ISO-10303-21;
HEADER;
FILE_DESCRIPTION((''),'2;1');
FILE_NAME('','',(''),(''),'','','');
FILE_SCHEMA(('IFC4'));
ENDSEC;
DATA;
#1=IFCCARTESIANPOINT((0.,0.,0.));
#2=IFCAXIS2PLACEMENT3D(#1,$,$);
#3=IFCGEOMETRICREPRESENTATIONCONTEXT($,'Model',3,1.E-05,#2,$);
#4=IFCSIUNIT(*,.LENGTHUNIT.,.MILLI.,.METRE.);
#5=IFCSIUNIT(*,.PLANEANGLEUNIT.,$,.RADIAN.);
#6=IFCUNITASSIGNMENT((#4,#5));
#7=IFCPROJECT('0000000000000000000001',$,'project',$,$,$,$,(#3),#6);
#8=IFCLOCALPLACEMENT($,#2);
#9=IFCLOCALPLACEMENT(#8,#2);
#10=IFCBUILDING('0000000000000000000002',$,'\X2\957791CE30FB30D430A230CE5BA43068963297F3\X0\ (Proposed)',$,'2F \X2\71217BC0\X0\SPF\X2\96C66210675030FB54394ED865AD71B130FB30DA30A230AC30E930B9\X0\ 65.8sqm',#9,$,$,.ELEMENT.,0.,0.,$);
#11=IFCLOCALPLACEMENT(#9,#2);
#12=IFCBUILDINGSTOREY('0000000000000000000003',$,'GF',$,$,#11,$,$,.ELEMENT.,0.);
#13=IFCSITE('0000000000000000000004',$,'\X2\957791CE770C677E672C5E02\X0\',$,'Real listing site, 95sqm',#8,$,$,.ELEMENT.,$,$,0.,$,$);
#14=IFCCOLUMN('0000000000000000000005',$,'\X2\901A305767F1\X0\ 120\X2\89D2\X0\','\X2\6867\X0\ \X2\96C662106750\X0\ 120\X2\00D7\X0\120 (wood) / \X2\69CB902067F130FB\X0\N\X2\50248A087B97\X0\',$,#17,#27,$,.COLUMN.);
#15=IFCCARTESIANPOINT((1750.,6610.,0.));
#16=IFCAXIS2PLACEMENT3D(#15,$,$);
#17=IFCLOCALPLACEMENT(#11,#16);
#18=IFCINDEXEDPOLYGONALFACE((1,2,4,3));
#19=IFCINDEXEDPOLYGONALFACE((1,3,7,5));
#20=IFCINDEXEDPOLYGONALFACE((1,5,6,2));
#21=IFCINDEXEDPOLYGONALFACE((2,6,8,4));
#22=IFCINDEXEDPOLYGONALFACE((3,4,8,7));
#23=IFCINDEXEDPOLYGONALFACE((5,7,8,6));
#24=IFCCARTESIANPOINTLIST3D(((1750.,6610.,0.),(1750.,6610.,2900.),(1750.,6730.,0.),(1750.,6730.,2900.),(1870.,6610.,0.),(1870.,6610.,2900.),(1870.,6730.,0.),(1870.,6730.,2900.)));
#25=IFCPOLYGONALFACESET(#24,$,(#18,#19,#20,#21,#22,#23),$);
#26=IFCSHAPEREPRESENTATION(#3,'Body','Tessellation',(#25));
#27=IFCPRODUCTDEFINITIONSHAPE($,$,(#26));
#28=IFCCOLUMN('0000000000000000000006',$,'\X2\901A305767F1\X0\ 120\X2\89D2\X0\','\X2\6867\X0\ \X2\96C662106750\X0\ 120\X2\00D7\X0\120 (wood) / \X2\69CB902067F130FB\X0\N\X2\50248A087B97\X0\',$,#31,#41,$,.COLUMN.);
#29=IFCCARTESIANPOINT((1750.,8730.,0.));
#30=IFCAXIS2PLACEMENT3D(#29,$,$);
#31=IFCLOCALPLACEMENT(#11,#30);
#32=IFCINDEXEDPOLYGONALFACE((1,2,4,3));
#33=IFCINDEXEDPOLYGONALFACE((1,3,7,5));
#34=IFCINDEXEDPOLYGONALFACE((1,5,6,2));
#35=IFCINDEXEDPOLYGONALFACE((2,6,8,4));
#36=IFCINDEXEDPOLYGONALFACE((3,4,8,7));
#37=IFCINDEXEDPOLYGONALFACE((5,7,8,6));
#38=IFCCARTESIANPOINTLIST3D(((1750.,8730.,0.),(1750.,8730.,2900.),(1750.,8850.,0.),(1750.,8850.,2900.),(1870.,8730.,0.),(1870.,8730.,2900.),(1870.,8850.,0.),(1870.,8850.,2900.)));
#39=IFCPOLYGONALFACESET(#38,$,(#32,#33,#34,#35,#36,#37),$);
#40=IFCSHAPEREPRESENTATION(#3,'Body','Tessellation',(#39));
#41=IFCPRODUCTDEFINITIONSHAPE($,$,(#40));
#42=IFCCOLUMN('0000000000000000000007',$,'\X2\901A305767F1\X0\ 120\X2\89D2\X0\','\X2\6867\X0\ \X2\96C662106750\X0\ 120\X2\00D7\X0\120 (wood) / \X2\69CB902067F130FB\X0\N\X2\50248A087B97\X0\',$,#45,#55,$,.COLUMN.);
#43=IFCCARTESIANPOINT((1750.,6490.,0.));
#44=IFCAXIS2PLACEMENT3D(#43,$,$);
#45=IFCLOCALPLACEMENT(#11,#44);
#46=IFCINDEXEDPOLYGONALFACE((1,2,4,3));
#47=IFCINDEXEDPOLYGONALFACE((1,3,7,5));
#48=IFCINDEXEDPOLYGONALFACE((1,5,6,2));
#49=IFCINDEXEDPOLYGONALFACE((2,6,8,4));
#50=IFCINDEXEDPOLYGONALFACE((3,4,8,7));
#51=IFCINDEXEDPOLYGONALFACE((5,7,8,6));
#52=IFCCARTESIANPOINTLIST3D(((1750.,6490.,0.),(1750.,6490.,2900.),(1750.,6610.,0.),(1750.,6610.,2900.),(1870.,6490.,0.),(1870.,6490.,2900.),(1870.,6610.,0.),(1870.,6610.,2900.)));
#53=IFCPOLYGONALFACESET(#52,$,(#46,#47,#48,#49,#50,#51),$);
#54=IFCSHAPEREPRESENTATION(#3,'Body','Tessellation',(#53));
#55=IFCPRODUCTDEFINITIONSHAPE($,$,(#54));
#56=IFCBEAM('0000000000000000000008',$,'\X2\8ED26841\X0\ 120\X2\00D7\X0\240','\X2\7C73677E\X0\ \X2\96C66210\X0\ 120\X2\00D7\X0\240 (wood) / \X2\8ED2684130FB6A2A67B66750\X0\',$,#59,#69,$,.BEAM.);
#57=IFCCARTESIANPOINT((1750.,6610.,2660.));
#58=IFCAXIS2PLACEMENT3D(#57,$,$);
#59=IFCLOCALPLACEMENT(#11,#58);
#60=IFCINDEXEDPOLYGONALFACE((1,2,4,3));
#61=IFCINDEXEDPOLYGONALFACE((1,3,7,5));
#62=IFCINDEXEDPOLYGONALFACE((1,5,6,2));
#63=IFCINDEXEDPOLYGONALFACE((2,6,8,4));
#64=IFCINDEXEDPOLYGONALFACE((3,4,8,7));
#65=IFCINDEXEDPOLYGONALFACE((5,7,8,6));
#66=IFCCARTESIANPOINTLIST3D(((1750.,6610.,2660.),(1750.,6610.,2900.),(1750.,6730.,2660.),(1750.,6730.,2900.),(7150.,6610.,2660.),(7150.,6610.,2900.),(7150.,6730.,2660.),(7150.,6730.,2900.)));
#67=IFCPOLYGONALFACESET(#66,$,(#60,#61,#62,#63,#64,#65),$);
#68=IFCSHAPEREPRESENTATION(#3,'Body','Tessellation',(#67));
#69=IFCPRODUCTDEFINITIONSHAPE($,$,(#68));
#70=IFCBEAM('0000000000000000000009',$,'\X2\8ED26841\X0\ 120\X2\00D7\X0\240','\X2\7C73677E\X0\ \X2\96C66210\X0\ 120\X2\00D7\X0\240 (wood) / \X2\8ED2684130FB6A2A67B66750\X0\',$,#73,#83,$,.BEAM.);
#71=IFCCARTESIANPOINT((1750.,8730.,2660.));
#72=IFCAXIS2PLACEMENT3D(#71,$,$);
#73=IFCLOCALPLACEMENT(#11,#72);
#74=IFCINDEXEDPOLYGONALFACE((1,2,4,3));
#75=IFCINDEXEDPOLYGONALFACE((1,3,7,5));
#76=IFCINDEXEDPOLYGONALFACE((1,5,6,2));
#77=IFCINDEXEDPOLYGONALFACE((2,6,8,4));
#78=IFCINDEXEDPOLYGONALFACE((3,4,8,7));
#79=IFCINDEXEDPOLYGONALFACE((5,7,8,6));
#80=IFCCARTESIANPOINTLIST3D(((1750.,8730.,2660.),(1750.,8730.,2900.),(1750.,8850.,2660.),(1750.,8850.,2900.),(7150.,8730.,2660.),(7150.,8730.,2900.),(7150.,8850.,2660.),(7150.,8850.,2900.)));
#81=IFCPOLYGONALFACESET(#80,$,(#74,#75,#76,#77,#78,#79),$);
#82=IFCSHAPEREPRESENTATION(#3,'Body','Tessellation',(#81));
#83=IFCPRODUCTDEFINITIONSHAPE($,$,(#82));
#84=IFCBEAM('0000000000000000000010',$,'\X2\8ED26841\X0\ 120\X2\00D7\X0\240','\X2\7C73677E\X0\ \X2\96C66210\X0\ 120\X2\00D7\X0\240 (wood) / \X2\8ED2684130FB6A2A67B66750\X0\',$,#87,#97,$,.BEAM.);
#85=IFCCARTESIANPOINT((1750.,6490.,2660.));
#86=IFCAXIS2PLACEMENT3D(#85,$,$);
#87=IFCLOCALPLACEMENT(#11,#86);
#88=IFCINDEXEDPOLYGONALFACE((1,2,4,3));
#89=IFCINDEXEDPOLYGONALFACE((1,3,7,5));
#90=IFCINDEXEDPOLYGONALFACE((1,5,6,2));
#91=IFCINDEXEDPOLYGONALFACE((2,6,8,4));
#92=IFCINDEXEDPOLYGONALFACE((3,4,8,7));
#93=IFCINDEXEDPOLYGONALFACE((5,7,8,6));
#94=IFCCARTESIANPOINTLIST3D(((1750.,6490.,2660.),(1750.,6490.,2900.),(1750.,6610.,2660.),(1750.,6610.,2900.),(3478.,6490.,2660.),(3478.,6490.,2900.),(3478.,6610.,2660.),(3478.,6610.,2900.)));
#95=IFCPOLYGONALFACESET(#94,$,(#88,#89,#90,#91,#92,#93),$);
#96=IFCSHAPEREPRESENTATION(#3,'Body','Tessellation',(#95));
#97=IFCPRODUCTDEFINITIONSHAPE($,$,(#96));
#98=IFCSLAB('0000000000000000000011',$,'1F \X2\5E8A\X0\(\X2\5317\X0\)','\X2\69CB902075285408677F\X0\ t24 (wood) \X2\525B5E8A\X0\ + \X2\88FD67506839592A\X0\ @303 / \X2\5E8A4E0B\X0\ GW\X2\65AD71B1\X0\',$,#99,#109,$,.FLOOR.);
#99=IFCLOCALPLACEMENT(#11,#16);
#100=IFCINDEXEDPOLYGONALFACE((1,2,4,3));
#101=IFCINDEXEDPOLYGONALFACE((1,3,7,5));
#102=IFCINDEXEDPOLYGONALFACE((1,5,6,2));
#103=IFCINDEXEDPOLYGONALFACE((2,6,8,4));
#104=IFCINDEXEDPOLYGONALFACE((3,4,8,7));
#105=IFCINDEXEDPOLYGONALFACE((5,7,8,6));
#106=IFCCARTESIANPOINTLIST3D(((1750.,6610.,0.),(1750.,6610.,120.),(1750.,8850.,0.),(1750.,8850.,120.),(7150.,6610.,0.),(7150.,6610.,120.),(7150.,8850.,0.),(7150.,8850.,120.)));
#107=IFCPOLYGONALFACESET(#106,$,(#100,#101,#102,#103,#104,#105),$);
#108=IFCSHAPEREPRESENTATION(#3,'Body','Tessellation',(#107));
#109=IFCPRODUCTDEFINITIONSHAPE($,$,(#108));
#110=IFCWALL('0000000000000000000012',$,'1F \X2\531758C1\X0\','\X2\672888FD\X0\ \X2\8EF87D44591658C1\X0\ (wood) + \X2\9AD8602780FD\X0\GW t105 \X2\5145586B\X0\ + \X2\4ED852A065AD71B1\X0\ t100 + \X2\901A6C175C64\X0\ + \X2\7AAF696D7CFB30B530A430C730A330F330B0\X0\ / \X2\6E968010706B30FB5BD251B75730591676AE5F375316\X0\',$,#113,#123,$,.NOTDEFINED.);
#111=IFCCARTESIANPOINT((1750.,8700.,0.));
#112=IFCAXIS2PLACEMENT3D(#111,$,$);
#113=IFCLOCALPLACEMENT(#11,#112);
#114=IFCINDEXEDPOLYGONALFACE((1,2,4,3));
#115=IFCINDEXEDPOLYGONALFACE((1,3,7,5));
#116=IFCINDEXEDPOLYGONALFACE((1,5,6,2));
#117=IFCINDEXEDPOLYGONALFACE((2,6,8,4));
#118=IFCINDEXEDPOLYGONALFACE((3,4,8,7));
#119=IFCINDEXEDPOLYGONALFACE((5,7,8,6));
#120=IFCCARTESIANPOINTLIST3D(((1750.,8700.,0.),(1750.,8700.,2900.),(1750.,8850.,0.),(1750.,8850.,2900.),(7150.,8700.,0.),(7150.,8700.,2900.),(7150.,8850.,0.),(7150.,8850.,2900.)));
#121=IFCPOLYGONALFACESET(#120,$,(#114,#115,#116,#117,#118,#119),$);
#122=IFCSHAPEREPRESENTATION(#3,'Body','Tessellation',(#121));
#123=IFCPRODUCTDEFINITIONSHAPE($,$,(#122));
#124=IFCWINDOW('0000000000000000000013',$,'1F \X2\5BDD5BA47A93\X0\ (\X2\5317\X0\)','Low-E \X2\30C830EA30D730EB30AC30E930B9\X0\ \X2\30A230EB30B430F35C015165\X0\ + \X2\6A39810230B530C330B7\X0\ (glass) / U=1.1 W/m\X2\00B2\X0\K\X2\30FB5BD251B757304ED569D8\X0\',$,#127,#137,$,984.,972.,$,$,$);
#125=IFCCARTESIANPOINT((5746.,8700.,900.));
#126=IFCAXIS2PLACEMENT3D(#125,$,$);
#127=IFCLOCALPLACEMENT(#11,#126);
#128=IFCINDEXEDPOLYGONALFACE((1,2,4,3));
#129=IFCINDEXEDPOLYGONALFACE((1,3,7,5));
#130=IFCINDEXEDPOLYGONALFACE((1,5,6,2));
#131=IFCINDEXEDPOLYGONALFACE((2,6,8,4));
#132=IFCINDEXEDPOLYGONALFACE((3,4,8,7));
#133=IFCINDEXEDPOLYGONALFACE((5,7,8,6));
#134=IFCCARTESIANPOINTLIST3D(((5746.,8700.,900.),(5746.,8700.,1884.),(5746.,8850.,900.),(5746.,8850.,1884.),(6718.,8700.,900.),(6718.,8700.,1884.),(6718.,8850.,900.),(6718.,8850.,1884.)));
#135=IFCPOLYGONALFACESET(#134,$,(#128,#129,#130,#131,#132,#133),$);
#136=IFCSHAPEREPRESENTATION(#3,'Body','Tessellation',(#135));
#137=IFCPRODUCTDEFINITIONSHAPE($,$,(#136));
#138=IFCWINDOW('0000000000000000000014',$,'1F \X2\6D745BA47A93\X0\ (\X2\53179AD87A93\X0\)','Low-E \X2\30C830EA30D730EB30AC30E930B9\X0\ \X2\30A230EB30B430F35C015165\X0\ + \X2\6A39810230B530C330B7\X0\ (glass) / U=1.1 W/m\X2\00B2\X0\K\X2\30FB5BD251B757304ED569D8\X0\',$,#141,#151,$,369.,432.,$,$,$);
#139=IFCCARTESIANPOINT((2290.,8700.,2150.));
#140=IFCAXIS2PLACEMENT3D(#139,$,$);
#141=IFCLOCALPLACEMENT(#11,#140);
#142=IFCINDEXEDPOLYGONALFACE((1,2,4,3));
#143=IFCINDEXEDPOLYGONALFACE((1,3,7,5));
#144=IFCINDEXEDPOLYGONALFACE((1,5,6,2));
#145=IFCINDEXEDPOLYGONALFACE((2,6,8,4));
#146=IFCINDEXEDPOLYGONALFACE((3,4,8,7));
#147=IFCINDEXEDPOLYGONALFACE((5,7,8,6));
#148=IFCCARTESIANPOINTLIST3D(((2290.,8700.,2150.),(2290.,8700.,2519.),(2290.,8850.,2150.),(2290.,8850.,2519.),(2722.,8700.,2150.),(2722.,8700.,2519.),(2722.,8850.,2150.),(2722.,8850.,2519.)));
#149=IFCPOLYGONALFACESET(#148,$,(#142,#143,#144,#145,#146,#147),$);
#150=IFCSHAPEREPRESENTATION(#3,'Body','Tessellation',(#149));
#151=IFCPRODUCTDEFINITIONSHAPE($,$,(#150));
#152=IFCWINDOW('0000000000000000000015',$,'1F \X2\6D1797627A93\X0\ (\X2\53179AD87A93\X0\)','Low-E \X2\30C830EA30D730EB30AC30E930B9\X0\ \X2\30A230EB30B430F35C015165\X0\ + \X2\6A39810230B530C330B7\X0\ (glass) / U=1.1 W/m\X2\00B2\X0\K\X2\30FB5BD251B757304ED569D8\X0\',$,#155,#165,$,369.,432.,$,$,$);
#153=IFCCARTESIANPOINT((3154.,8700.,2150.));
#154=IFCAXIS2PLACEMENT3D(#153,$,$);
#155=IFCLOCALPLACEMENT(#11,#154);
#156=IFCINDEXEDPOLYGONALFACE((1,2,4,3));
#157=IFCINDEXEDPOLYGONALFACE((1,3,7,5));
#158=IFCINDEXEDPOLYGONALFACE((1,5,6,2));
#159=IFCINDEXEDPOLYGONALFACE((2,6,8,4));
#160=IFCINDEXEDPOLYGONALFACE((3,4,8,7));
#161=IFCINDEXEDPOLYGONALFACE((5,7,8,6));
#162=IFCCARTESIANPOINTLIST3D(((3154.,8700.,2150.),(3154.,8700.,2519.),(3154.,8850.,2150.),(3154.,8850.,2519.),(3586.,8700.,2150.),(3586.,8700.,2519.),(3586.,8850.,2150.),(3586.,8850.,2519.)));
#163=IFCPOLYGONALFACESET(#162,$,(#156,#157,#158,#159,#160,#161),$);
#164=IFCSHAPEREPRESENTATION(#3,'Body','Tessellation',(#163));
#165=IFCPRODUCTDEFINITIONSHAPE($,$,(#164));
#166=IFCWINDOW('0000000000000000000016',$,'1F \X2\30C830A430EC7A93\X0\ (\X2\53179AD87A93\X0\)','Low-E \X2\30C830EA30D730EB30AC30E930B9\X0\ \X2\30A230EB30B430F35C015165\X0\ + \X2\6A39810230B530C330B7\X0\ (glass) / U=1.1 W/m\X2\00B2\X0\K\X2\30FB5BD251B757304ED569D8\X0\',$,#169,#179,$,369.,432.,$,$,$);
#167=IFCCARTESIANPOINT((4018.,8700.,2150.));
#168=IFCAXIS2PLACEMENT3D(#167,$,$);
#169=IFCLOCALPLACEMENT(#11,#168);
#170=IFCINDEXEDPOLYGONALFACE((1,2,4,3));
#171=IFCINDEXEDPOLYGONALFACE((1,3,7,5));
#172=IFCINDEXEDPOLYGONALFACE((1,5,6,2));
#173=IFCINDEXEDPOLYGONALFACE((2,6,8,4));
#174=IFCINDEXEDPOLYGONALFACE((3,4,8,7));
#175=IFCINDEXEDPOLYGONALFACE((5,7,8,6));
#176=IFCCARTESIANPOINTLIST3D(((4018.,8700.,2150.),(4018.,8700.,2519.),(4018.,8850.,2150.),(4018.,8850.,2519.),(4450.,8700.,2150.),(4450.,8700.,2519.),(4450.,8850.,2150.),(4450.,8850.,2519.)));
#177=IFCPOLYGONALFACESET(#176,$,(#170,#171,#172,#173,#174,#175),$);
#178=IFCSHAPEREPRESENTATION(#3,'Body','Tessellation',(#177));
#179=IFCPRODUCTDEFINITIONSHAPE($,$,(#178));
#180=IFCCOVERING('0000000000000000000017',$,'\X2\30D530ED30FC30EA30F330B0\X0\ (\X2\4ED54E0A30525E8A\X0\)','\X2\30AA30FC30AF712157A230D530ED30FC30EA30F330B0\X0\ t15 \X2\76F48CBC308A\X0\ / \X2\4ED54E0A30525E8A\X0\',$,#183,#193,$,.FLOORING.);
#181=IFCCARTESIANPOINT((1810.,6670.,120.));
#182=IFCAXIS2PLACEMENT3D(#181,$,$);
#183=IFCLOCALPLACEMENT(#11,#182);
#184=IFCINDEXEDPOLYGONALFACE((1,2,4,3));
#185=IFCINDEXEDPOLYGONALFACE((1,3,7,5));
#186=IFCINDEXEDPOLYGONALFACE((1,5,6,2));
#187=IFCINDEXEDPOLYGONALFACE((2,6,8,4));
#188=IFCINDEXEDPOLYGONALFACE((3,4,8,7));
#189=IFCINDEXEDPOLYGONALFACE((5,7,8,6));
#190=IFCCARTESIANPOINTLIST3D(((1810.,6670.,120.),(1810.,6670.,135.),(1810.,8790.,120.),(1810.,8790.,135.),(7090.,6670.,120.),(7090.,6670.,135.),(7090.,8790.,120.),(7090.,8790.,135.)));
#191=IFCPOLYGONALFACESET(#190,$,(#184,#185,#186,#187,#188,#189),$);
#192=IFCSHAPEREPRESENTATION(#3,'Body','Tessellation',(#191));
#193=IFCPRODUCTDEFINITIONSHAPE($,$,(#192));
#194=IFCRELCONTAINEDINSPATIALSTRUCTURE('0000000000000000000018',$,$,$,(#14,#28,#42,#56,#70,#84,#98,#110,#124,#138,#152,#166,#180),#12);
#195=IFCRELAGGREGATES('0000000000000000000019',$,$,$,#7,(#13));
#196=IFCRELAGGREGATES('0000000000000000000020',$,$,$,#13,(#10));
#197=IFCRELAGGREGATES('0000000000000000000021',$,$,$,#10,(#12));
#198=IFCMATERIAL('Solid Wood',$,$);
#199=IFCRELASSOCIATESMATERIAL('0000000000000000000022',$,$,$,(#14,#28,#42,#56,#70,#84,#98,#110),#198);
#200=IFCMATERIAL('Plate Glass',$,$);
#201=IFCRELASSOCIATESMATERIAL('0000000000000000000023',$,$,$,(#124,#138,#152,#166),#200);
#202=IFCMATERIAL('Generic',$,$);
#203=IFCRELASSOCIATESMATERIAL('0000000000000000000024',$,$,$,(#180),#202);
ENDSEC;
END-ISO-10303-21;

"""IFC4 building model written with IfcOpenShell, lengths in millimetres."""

from ifc_helpers import new_model, si_unit, frame, frame_2d, origin, place, context, project, spatial, rectangle, extrude, material, element, fill, save


model = new_model("IFC4")

# Units and contexts
model_context = context("Model", 3, precision=1e-05, world=origin())
ifc_project = project(units=[si_unit("LENGTHUNIT", "METRE", prefix="MILLI"), si_unit("PLANEANGLEUNIT", "RADIAN")], contexts=[model_context])

# Site, building, storey
site_placement = place(None, origin())
site = spatial("IfcSite", under=ifc_project, at=site_placement, Name="長野県松本市", ObjectType="Real listing site, 95sqm", CompositionType="ELEMENT", RefElevation=0.0)
building_placement = place(site_placement, origin())
building = spatial("IfcBuilding", under=site, at=building_placement, Name="長野・ピアノ室と防音 (Proposed)", ObjectType="2F 無節SPF集成材・吹付断熱・ペアガラス 65.8sqm", CompositionType="ELEMENT", ElevationOfRefHeight=0.0, ElevationOfTerrain=0.0)
storey_placement = place(building_placement, origin())
storey = spatial("IfcBuildingStorey", under=building, at=storey_placement, Name="GF", CompositionType="ELEMENT", Elevation=0.0)

# Columns
ifc_material_1 = material(Name="Solid Wood")
column_1_placement = place(storey_placement, frame((1750.0, 6610.0, 0.0)))
element("IfcColumn", 1, at=column_1_placement, inside=storey, material=ifc_material_1, Name="通し柱 120角", Description="桧 集成材 120×120 (wood) / 構造柱・N値計算", PredefinedType="COLUMN", context=model_context, shape_type="SweptSolid", body=[
    extrude(rectangle(XDim=120.0, YDim=120.0, at=frame_2d((60.0, 60.0))), frame((1750.0, 6610.0, 0.0)), (0.0, 0.0, 1.0), 2900.0),
])
column_2_placement = place(storey_placement, frame((1750.0, 8730.0, 0.0)))
element("IfcColumn", 2, at=column_2_placement, inside=storey, material=ifc_material_1, Name="通し柱 120角", Description="桧 集成材 120×120 (wood) / 構造柱・N値計算", PredefinedType="COLUMN", context=model_context, shape_type="SweptSolid", body=[
    extrude(rectangle(XDim=120.0, YDim=120.0, at=frame_2d((60.0, 60.0))), frame((1750.0, 8730.0, 0.0)), (0.0, 0.0, 1.0), 2900.0),
])
column_3_placement = place(storey_placement, frame((1750.0, 6490.0, 0.0)))
element("IfcColumn", 3, at=column_3_placement, inside=storey, material=ifc_material_1, Name="通し柱 120角", Description="桧 集成材 120×120 (wood) / 構造柱・N値計算", PredefinedType="COLUMN", context=model_context, shape_type="SweptSolid", body=[
    extrude(rectangle(XDim=120.0, YDim=120.0, at=frame_2d((60.0, 60.0))), frame((1750.0, 6490.0, 0.0)), (0.0, 0.0, 1.0), 2900.0),
])

# Beams
beam_1_placement = place(storey_placement, frame((1750.0, 6610.0, 2660.0)))
element("IfcBeam", 4, at=beam_1_placement, inside=storey, material=ifc_material_1, Name="軒桁 120×240", Description="米松 集成 120×240 (wood) / 軒桁・横架材", PredefinedType="BEAM", context=model_context, shape_type="SweptSolid", body=[
    extrude(rectangle(XDim=5400.0, YDim=120.0, at=frame_2d((2700.0, 60.0))), frame((1750.0, 6610.0, 2660.0)), (0.0, 0.0, 1.0), 240.0),
])
beam_2_placement = place(storey_placement, frame((1750.0, 8730.0, 2660.0)))
element("IfcBeam", 5, at=beam_2_placement, inside=storey, material=ifc_material_1, Name="軒桁 120×240", Description="米松 集成 120×240 (wood) / 軒桁・横架材", PredefinedType="BEAM", context=model_context, shape_type="SweptSolid", body=[
    extrude(rectangle(XDim=5400.0, YDim=120.0, at=frame_2d((2700.0, 60.0))), frame((1750.0, 8730.0, 2660.0)), (0.0, 0.0, 1.0), 240.0),
])
beam_3_placement = place(storey_placement, frame((1750.0, 6490.0, 2660.0)))
element("IfcBeam", 6, at=beam_3_placement, inside=storey, material=ifc_material_1, Name="軒桁 120×240", Description="米松 集成 120×240 (wood) / 軒桁・横架材", PredefinedType="BEAM", context=model_context, shape_type="SweptSolid", body=[
    extrude(rectangle(XDim=1728.0, YDim=120.0, at=frame_2d((864.0, 60.0))), frame((1750.0, 6490.0, 2660.0)), (0.0, 0.0, 1.0), 240.0),
])

# Slab
slab_placement = place(storey_placement, frame((1750.0, 6610.0, 0.0)))
element("IfcSlab", 7, at=slab_placement, inside=storey, material=ifc_material_1, Name="1F 床(北)", Description="構造用合板 t24 (wood) 剛床 + 製材根太 @303 / 床下 GW断熱", PredefinedType="FLOOR", context=model_context, shape_type="SweptSolid", body=[
    extrude(rectangle(XDim=5400.0, YDim=2240.0, at=frame_2d((2700.0, 1120.0))), frame((1750.0, 6610.0, 0.0)), (0.0, 0.0, 1.0), 120.0),
])

# Wall, openings, windows
wall_1_placement = place(storey_placement, frame((1750.0, 8700.0, 0.0)))
wall_1 = element("IfcWall", 8, at=wall_1_placement, inside=storey, material=ifc_material_1, Name="1F 北壁", Description="木製 軸組外壁 (wood) + 高性能GW t105 充填 + 付加断熱 t100 + 通気層 + 窯業系サイディング / 準耐火・寒冷地外皮強化", PredefinedType="NOTDEFINED", context=model_context, shape_type="SweptSolid", body=[
    extrude(rectangle(XDim=5400.0, YDim=150.0, at=frame_2d((2700.0, 75.0))), frame((1750.0, 8700.0, 0.0)), (0.0, 0.0, 1.0), 2900.0),
])
opening_1_placement = place(storey_placement, frame((5746.0, 8700.0, 900.0)))
opening_1 = element("IfcOpeningElement", 9, at=opening_1_placement, cuts=wall_1, PredefinedType="NOTDEFINED", context=model_context, shape_type="SweptSolid", body=[
    extrude(rectangle(XDim=972.0, YDim=150.0, at=frame_2d((486.0, 75.0))), frame((5746.0, 8700.0, 900.0)), (0.0, 0.0, 1.0), 984.0),
])
opening_2_placement = place(storey_placement, frame((2290.0, 8700.0, 2150.0)))
opening_2 = element("IfcOpeningElement", 10, at=opening_2_placement, cuts=wall_1, PredefinedType="NOTDEFINED", context=model_context, shape_type="SweptSolid", body=[
    extrude(rectangle(XDim=432.0, YDim=150.0, at=frame_2d((216.0, 75.0))), frame((2290.0, 8700.0, 2150.0)), (0.0, 0.0, 1.0), 369.0),
])
opening_3_placement = place(storey_placement, frame((3154.0, 8700.0, 2150.0)))
opening_3 = element("IfcOpeningElement", 11, at=opening_3_placement, cuts=wall_1, PredefinedType="NOTDEFINED", context=model_context, shape_type="SweptSolid", body=[
    extrude(rectangle(XDim=432.0, YDim=150.0, at=frame_2d((216.0, 75.0))), frame((3154.0, 8700.0, 2150.0)), (0.0, 0.0, 1.0), 369.0),
])
opening_4_placement = place(storey_placement, frame((4018.0, 8700.0, 2150.0)))
opening_4 = element("IfcOpeningElement", 12, at=opening_4_placement, cuts=wall_1, PredefinedType="NOTDEFINED", context=model_context, shape_type="SweptSolid", body=[
    extrude(rectangle(XDim=432.0, YDim=150.0, at=frame_2d((216.0, 75.0))), frame((4018.0, 8700.0, 2150.0)), (0.0, 0.0, 1.0), 369.0),
])
ifc_material_2 = material(Name="Plate Glass")
window_1_placement = place(storey_placement, frame((5746.0, 8700.0, 900.0)))
window_1 = element("IfcWindow", 13, at=window_1_placement, inside=storey, material=ifc_material_2, Name="1F 寝室窓 (北)", Description="Low-E トリプルガラス アルゴン封入 + 樹脂サッシ (glass) / U=1.1 W/m²K・寒冷地仕様", OverallHeight=984.0, OverallWidth=972.0, context=model_context, shape_type="SweptSolid", body=[
    extrude(rectangle(XDim=972.0, YDim=150.0, at=frame_2d((486.0, 75.0))), frame((5746.0, 8700.0, 900.0)), (0.0, 0.0, 1.0), 984.0),
])
fill(opening_1, window_1)
window_2_placement = place(storey_placement, frame((2290.0, 8700.0, 2150.0)))
window_2 = element("IfcWindow", 14, at=window_2_placement, inside=storey, material=ifc_material_2, Name="1F 浴室窓 (北高窓)", Description="Low-E トリプルガラス アルゴン封入 + 樹脂サッシ (glass) / U=1.1 W/m²K・寒冷地仕様", OverallHeight=369.0, OverallWidth=432.0, context=model_context, shape_type="SweptSolid", body=[
    extrude(rectangle(XDim=432.0, YDim=150.0, at=frame_2d((216.0, 75.0))), frame((2290.0, 8700.0, 2150.0)), (0.0, 0.0, 1.0), 369.0),
])
fill(opening_2, window_2)
window_3_placement = place(storey_placement, frame((3154.0, 8700.0, 2150.0)))
window_3 = element("IfcWindow", 15, at=window_3_placement, inside=storey, material=ifc_material_2, Name="1F 洗面窓 (北高窓)", Description="Low-E トリプルガラス アルゴン封入 + 樹脂サッシ (glass) / U=1.1 W/m²K・寒冷地仕様", OverallHeight=369.0, OverallWidth=432.0, context=model_context, shape_type="SweptSolid", body=[
    extrude(rectangle(XDim=432.0, YDim=150.0, at=frame_2d((216.0, 75.0))), frame((3154.0, 8700.0, 2150.0)), (0.0, 0.0, 1.0), 369.0),
])
fill(opening_3, window_3)
window_4_placement = place(storey_placement, frame((4018.0, 8700.0, 2150.0)))
window_4 = element("IfcWindow", 16, at=window_4_placement, inside=storey, material=ifc_material_2, Name="1F トイレ窓 (北高窓)", Description="Low-E トリプルガラス アルゴン封入 + 樹脂サッシ (glass) / U=1.1 W/m²K・寒冷地仕様", OverallHeight=369.0, OverallWidth=432.0, context=model_context, shape_type="SweptSolid", body=[
    extrude(rectangle(XDim=432.0, YDim=150.0, at=frame_2d((216.0, 75.0))), frame((4018.0, 8700.0, 2150.0)), (0.0, 0.0, 1.0), 369.0),
])
fill(opening_4, window_4)

# Covering
ifc_material_3 = material(Name="Generic")
covering_1_placement = place(storey_placement, frame((1810.0, 6670.0, 120.0)))
element("IfcCovering", 17, at=covering_1_placement, inside=storey, material=ifc_material_3, Name="フローリング (仕上げ床)", Description="オーク無垢フローリング t15 直貼り / 仕上げ床", PredefinedType="FLOORING", context=model_context, shape_type="SweptSolid", body=[
    extrude(rectangle(XDim=5280.0, YDim=2120.0, at=frame_2d((2640.0, 1060.0))), frame((1810.0, 6670.0, 120.0)), (0.0, 0.0, 1.0), 15.0),
])

save(model, "model.ifc")
